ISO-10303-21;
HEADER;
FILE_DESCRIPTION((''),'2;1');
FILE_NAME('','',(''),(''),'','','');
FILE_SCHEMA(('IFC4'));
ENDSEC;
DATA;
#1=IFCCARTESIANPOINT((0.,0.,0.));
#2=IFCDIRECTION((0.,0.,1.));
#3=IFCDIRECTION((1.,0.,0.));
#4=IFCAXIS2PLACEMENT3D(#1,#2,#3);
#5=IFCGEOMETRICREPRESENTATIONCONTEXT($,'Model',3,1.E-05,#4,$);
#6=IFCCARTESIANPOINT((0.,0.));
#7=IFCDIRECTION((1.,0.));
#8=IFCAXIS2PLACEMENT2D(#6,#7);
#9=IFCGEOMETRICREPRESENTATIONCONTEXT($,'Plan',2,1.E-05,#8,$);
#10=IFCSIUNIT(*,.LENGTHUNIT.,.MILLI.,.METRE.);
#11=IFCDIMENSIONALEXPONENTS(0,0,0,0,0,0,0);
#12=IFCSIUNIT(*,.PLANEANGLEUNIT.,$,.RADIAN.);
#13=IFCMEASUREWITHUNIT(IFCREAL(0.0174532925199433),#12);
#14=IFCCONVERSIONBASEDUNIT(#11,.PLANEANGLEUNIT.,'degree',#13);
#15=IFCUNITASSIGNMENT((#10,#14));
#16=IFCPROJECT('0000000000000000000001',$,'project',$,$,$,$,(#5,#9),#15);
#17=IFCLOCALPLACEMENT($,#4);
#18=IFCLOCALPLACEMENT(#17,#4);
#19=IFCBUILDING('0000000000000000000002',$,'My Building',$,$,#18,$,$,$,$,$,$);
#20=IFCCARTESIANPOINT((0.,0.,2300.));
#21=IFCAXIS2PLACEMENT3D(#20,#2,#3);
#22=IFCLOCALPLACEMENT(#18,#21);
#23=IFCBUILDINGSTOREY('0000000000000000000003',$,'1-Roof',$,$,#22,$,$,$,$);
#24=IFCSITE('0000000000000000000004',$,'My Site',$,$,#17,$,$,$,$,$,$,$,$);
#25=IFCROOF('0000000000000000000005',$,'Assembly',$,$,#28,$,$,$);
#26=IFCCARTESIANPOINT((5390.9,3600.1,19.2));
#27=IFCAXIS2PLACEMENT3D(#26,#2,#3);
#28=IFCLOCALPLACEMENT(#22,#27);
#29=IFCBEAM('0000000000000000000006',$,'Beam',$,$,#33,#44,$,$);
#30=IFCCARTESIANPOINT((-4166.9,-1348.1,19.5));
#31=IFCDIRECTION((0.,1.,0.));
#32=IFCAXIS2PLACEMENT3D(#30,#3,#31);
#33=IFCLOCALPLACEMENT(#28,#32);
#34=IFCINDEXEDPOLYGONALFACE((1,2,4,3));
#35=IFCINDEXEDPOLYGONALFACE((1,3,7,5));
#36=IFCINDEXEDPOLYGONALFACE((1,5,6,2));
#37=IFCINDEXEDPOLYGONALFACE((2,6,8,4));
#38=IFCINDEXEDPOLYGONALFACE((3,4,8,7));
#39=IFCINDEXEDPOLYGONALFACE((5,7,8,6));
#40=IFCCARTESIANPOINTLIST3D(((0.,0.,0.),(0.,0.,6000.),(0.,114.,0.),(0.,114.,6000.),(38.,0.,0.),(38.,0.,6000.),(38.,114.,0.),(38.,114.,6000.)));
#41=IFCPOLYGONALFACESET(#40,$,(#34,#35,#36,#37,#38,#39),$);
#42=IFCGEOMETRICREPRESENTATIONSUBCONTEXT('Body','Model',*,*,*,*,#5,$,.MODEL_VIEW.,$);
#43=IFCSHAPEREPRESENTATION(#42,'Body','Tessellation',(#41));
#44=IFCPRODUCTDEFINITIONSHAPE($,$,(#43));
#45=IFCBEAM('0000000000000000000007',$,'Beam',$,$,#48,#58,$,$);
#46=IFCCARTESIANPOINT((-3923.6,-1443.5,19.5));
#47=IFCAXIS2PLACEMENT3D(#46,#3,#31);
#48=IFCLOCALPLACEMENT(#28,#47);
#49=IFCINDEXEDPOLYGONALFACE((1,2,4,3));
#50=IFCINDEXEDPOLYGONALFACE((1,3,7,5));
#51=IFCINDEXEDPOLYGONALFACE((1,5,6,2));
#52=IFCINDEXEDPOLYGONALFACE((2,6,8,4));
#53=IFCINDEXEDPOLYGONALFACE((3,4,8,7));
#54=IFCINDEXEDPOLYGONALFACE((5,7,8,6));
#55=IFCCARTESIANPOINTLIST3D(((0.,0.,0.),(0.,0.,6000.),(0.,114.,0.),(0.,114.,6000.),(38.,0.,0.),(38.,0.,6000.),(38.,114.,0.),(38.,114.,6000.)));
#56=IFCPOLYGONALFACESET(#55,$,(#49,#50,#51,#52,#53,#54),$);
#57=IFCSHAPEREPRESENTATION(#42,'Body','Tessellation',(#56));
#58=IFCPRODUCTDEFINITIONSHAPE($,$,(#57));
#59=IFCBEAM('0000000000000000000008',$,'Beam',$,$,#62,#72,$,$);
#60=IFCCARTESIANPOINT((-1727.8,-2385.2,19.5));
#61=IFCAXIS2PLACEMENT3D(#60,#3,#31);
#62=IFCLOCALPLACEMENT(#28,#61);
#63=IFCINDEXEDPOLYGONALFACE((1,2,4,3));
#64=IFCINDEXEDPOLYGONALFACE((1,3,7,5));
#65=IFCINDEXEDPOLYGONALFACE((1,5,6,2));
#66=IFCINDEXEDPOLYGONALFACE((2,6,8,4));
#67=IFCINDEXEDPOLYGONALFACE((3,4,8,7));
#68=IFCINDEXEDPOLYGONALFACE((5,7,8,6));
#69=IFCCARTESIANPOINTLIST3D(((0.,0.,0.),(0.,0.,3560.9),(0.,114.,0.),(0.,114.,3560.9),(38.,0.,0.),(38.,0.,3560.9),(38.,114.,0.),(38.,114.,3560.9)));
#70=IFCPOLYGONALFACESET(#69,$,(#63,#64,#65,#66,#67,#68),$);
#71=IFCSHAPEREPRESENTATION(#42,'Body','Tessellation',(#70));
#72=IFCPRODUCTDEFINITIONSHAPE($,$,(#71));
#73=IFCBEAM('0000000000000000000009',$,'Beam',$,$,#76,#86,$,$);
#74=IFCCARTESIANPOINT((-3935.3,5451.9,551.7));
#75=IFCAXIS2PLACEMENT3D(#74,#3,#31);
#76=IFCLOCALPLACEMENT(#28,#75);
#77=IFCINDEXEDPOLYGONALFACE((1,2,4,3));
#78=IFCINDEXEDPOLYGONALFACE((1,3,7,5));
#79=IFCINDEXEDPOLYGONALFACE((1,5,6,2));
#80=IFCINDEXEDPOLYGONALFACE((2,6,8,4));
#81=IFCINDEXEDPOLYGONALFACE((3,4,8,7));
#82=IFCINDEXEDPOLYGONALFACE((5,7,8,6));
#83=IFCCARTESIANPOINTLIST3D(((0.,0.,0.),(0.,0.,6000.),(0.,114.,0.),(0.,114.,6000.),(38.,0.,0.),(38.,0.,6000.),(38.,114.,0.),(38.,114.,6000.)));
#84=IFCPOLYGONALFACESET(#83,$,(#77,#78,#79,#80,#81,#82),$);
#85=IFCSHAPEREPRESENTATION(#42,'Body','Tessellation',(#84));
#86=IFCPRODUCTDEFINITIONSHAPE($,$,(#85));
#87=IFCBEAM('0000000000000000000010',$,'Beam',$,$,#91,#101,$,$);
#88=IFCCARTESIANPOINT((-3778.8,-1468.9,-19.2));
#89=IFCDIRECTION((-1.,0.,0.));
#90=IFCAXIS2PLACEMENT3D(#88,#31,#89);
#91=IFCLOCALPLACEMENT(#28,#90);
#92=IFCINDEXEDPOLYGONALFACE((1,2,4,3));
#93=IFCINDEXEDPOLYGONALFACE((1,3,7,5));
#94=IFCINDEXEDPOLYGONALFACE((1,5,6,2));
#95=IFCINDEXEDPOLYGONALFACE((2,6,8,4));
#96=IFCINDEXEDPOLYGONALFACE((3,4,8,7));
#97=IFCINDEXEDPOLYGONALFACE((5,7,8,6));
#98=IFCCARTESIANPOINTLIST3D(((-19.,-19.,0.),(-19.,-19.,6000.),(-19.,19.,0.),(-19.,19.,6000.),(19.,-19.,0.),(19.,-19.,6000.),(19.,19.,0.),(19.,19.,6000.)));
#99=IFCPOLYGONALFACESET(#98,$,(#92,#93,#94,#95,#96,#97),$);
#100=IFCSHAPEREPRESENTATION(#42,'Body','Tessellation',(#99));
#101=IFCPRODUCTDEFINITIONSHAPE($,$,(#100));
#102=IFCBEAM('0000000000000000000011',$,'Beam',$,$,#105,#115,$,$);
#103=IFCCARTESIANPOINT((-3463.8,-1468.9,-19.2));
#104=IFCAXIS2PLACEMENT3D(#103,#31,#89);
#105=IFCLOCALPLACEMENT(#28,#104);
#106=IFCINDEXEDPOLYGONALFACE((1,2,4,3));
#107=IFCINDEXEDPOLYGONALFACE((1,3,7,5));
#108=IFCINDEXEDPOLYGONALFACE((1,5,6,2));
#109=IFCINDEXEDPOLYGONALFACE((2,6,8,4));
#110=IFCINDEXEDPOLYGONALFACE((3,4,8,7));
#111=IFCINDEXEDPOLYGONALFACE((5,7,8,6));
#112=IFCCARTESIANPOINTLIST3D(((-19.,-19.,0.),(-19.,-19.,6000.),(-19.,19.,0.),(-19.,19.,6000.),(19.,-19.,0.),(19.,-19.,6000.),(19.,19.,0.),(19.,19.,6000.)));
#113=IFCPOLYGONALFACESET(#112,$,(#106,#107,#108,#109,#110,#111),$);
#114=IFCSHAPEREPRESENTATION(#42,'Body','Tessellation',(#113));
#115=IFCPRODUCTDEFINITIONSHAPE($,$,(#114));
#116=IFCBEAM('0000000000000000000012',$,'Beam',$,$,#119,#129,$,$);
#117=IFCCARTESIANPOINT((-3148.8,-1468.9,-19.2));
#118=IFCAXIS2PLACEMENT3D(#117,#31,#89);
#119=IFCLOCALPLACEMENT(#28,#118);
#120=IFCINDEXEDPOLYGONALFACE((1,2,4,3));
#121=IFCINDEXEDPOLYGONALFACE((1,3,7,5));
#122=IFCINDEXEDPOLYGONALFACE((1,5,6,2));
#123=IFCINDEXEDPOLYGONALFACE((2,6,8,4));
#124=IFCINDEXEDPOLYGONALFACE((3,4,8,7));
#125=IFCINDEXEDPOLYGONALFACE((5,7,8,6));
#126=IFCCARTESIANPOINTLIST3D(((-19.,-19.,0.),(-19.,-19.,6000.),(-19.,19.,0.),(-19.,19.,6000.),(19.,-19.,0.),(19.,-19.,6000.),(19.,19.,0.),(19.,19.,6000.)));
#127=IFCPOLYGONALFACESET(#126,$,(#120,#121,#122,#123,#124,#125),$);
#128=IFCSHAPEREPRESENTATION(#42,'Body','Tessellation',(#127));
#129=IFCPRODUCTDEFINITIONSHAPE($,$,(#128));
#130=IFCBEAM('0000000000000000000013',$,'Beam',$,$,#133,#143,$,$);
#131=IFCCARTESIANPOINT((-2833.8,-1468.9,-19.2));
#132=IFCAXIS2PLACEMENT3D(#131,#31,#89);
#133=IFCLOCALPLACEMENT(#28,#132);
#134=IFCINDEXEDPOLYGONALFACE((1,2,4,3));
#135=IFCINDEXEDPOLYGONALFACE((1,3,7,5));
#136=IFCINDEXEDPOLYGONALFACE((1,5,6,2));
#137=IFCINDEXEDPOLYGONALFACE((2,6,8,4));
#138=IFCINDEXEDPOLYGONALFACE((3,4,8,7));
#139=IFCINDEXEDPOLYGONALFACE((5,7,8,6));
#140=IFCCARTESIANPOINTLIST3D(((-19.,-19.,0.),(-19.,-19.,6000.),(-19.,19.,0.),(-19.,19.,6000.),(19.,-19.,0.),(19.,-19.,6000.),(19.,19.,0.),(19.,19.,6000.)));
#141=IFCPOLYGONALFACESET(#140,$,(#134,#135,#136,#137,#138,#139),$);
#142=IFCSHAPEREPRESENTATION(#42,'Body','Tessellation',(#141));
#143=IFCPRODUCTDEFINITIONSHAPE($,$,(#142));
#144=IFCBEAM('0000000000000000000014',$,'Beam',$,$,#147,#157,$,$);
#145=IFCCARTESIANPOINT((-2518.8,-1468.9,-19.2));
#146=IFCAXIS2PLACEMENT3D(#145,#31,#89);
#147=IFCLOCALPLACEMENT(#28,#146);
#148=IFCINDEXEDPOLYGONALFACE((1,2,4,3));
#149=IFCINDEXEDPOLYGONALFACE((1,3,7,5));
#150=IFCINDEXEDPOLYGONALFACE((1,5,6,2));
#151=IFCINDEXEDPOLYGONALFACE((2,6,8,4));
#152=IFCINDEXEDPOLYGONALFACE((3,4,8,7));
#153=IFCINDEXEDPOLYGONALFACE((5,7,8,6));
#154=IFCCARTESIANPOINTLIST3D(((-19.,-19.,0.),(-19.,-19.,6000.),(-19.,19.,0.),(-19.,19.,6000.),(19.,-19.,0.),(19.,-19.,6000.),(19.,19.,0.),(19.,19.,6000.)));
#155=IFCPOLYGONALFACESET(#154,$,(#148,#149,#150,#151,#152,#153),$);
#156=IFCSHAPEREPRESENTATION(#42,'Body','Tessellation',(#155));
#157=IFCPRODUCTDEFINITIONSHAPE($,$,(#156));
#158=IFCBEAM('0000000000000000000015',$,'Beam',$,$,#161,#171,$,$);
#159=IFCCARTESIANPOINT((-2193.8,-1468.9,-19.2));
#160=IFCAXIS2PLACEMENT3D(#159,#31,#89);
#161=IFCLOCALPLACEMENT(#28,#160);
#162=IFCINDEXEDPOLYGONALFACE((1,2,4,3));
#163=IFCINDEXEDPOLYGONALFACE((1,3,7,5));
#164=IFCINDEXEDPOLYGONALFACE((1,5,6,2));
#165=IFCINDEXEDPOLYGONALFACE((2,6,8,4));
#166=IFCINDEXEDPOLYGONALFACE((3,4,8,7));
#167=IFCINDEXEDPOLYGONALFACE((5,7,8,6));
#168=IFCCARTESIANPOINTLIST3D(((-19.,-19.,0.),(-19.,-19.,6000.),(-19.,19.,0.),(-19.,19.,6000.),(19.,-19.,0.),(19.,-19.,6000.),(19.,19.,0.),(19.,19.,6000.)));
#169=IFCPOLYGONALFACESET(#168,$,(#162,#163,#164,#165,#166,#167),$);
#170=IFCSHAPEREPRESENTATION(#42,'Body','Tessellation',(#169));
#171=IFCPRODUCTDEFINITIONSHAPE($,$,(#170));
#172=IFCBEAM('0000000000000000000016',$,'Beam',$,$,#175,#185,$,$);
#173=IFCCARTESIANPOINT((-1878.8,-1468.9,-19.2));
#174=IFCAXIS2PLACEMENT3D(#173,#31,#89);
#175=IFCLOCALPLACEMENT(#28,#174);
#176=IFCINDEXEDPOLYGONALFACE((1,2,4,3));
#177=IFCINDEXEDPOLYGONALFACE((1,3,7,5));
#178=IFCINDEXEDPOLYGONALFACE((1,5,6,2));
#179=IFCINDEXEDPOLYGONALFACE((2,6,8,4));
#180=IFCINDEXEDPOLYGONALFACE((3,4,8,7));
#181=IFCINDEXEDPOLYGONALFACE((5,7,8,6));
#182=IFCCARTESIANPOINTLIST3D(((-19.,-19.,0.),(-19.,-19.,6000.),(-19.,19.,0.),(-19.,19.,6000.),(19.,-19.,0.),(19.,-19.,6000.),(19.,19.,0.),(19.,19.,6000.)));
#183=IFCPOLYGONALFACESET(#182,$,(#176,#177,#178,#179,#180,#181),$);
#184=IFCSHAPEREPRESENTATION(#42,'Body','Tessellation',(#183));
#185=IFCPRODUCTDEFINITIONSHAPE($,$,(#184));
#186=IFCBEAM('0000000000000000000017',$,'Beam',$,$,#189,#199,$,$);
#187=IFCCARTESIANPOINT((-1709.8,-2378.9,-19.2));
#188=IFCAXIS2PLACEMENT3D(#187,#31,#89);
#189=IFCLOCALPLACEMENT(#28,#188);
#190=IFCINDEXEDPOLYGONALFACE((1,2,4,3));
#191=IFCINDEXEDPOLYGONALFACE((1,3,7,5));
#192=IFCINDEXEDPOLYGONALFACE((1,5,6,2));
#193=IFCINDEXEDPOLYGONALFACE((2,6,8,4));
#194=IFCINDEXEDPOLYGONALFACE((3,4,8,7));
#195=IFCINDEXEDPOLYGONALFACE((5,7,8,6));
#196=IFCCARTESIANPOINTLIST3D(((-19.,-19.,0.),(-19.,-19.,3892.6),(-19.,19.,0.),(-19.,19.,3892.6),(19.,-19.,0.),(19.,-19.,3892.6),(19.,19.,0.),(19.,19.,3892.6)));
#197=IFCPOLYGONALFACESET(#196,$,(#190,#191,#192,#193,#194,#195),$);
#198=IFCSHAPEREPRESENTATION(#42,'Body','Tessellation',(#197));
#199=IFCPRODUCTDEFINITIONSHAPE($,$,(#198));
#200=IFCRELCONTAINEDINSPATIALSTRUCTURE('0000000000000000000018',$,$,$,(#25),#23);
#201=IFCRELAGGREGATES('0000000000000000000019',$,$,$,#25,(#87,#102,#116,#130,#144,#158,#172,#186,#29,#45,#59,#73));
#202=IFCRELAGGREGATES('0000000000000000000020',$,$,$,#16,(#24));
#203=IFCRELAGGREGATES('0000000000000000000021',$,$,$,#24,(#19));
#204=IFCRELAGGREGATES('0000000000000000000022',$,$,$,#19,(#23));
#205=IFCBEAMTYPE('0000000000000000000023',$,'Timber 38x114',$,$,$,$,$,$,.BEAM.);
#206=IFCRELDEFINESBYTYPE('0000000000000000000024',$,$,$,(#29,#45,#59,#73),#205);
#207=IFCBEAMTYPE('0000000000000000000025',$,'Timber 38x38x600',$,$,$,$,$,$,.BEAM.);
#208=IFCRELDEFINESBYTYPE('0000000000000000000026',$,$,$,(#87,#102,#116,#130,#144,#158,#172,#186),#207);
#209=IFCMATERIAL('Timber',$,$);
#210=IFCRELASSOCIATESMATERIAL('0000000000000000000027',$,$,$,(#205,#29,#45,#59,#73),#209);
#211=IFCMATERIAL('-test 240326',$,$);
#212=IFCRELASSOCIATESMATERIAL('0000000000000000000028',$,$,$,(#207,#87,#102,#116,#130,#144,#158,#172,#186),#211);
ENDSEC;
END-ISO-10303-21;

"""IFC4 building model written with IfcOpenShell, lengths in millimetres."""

from ifc_helpers import new_model, entity, si_unit, converted_unit, frame, origin_with_axes, origin_2d_with_axis, place, context, subcontext, project, spatial, line, indexed_curve, rectangle, outline, extrude, material, material_profile, profile_set, profile_usage, type_object, element, aggregate, save


model = new_model("IFC4")

# Units and contexts
model_context = context("Model", 3, precision=1e-05, world=origin_with_axes())
plan_context = context("Plan", 2, precision=1e-05, world=origin_2d_with_axis())
body_context = subcontext(model_context, "Body", "Model", "MODEL_VIEW")
ifc_project = project(units=[si_unit("LENGTHUNIT", "METRE", prefix="MILLI"), converted_unit("PLANEANGLEUNIT", "degree", entity("IfcReal", 0.0174532925199433), si_unit("PLANEANGLEUNIT", "RADIAN"), dimensions=[0, 0, 0, 0, 0, 0, 0])], contexts=[model_context, plan_context])

# Site, building, storey
site_placement = place(None, origin_with_axes())
site = spatial("IfcSite", under=ifc_project, at=site_placement, Name="My Site")
building_placement = place(site_placement, origin_with_axes())
building = spatial("IfcBuilding", under=site, at=building_placement, Name="My Building")
storey_placement = place(building_placement, frame((0.0, 0.0, 2300.0), z_axis=(0.0, 0.0, 1.0), x_axis=(1.0, 0.0, 0.0)))
storey = spatial("IfcBuildingStorey", under=building, at=storey_placement, Name="1-Roof")

# Roof, beams
roof_placement = place(storey_placement, frame((5390.9, 3600.1, 19.2), z_axis=(0.0, 0.0, 1.0), x_axis=(1.0, 0.0, 0.0)))
roof = element("IfcRoof", 1, at=roof_placement, inside=storey, Name="Assembly")
ifc_material_1 = material(Name="Timber")
ifc_material_profile_1 = material_profile(ifc_material_1, outline(indexed_curve([(0.0, 0.0), (38.0, 0.0), (38.0, 114.0), (0.0, 114.0)], segments=[line(3, 2), line(2, 1), line(1, 4), line(4, 3)], self_intersect=False)))
ifc_profile_set_1 = profile_set([ifc_material_profile_1])
beam_type_1 = type_object("IfcBeamType", Name="Timber 38x114", PredefinedType="BEAM", material=ifc_profile_set_1)
ifc_profile_usage_1 = profile_usage(ifc_profile_set_1, cardinal=5)
beam_1_placement = place(roof_placement, frame((-4166.9, -1348.1, 19.5), z_axis=(1.0, 0.0, 0.0), x_axis=(0.0, 1.0, 0.0)))
beam_1 = element("IfcBeam", 2, at=beam_1_placement, type_object=beam_type_1, material=ifc_profile_usage_1, Name="Beam", context=body_context, shape_type="SweptSolid", body=[
    extrude(outline(indexed_curve([(0.0, 0.0), (38.0, 0.0), (38.0, 114.0), (0.0, 114.0)], segments=[line(3, 2), line(2, 1), line(1, 4), line(4, 3)], self_intersect=False)), origin_with_axes(), (0.0, 0.0, 1.0), 6000.0),
])
ifc_profile_usage_2 = profile_usage(ifc_profile_set_1, cardinal=5)
beam_2_placement = place(roof_placement, frame((-3923.6, -1443.5, 19.5), z_axis=(1.0, 0.0, 0.0), x_axis=(0.0, 1.0, 0.0)))
beam_2 = element("IfcBeam", 3, at=beam_2_placement, type_object=beam_type_1, material=ifc_profile_usage_2, Name="Beam", context=body_context, shape_type="SweptSolid", body=[
    extrude(outline(indexed_curve([(0.0, 0.0), (38.0, 0.0), (38.0, 114.0), (0.0, 114.0)], segments=[line(3, 2), line(2, 1), line(1, 4), line(4, 3)], self_intersect=False)), origin_with_axes(), (0.0, 0.0, 1.0), 6000.0),
])
ifc_profile_usage_3 = profile_usage(ifc_profile_set_1, cardinal=5)
beam_3_placement = place(roof_placement, frame((-1727.8, -2385.2, 19.5), z_axis=(1.0, 0.0, 0.0), x_axis=(0.0, 1.0, 0.0)))
beam_3 = element("IfcBeam", 4, at=beam_3_placement, type_object=beam_type_1, material=ifc_profile_usage_3, Name="Beam", context=body_context, shape_type="SweptSolid", body=[
    extrude(outline(indexed_curve([(0.0, 0.0), (38.0, 0.0), (38.0, 114.0), (0.0, 114.0)], segments=[line(3, 2), line(2, 1), line(1, 4), line(4, 3)], self_intersect=False)), origin_with_axes(), (0.0, 0.0, 1.0), 3560.9),
])
ifc_profile_usage_4 = profile_usage(ifc_profile_set_1, cardinal=5)
beam_4_placement = place(roof_placement, frame((-3935.3, 5451.9, 551.7), z_axis=(1.0, 0.0, 0.0), x_axis=(0.0, 1.0, 0.0)))
beam_4 = element("IfcBeam", 5, at=beam_4_placement, type_object=beam_type_1, material=ifc_profile_usage_4, Name="Beam", context=body_context, shape_type="SweptSolid", body=[
    extrude(outline(indexed_curve([(0.0, 0.0), (38.0, 0.0), (38.0, 114.0), (0.0, 114.0)], segments=[line(3, 2), line(2, 1), line(1, 4), line(4, 3)], self_intersect=False)), origin_with_axes(), (0.0, 0.0, 1.0), 6000.0),
])
ifc_material_2 = material(Name="-test 240326")
ifc_material_profile_2 = material_profile(ifc_material_2, rectangle(XDim=38.0, YDim=38.0))
ifc_profile_set_2 = profile_set([ifc_material_profile_2])
ifc_profile_usage_5 = profile_usage(ifc_profile_set_2, cardinal=5)
beam_type_2 = type_object("IfcBeamType", Name="Timber 38x38x600", PredefinedType="BEAM", material=ifc_profile_set_2)
beam_5_placement = place(roof_placement, frame((-3778.8, -1468.9, -19.2), z_axis=(0.0, 1.0, 0.0), x_axis=(-1.0, 0.0, 0.0)))
beam_5 = element("IfcBeam", 6, at=beam_5_placement, type_object=beam_type_2, material=ifc_profile_usage_5, Name="Beam", context=body_context, shape_type="SweptSolid", body=[
    extrude(rectangle(XDim=38.0, YDim=38.0), origin_with_axes(), (0.0, 0.0, 1.0), 6000.0),
])
ifc_profile_usage_6 = profile_usage(ifc_profile_set_2, cardinal=5)
beam_6_placement = place(roof_placement, frame((-3463.8, -1468.9, -19.2), z_axis=(0.0, 1.0, 0.0), x_axis=(-1.0, 0.0, 0.0)))
beam_6 = element("IfcBeam", 7, at=beam_6_placement, type_object=beam_type_2, material=ifc_profile_usage_6, Name="Beam", context=body_context, shape_type="SweptSolid", body=[
    extrude(rectangle(XDim=38.0, YDim=38.0), origin_with_axes(), (0.0, 0.0, 1.0), 6000.0),
])
ifc_profile_usage_7 = profile_usage(ifc_profile_set_2, cardinal=5)
beam_7_placement = place(roof_placement, frame((-3148.8, -1468.9, -19.2), z_axis=(0.0, 1.0, 0.0), x_axis=(-1.0, 0.0, 0.0)))
beam_7 = element("IfcBeam", 8, at=beam_7_placement, type_object=beam_type_2, material=ifc_profile_usage_7, Name="Beam", context=body_context, shape_type="SweptSolid", body=[
    extrude(rectangle(XDim=38.0, YDim=38.0), origin_with_axes(), (0.0, 0.0, 1.0), 6000.0),
])
ifc_profile_usage_8 = profile_usage(ifc_profile_set_2, cardinal=5)
beam_8_placement = place(roof_placement, frame((-2833.8, -1468.9, -19.2), z_axis=(0.0, 1.0, 0.0), x_axis=(-1.0, 0.0, 0.0)))
beam_8 = element("IfcBeam", 9, at=beam_8_placement, type_object=beam_type_2, material=ifc_profile_usage_8, Name="Beam", context=body_context, shape_type="SweptSolid", body=[
    extrude(rectangle(XDim=38.0, YDim=38.0), origin_with_axes(), (0.0, 0.0, 1.0), 6000.0),
])
ifc_profile_usage_9 = profile_usage(ifc_profile_set_2, cardinal=5)
beam_9_placement = place(roof_placement, frame((-2518.8, -1468.9, -19.2), z_axis=(0.0, 1.0, 0.0), x_axis=(-1.0, 0.0, 0.0)))
beam_9 = element("IfcBeam", 10, at=beam_9_placement, type_object=beam_type_2, material=ifc_profile_usage_9, Name="Beam", context=body_context, shape_type="SweptSolid", body=[
    extrude(rectangle(XDim=38.0, YDim=38.0), origin_with_axes(), (0.0, 0.0, 1.0), 6000.0),
])
ifc_profile_usage_10 = profile_usage(ifc_profile_set_2, cardinal=5)
beam_10_placement = place(roof_placement, frame((-2193.8, -1468.9, -19.2), z_axis=(0.0, 1.0, 0.0), x_axis=(-1.0, 0.0, 0.0)))
beam_10 = element("IfcBeam", 11, at=beam_10_placement, type_object=beam_type_2, material=ifc_profile_usage_10, Name="Beam", context=body_context, shape_type="SweptSolid", body=[
    extrude(rectangle(XDim=38.0, YDim=38.0), origin_with_axes(), (0.0, 0.0, 1.0), 6000.0),
])
ifc_profile_usage_11 = profile_usage(ifc_profile_set_2, cardinal=5)
beam_11_placement = place(roof_placement, frame((-1878.8, -1468.9, -19.2), z_axis=(0.0, 1.0, 0.0), x_axis=(-1.0, 0.0, 0.0)))
beam_11 = element("IfcBeam", 12, at=beam_11_placement, type_object=beam_type_2, material=ifc_profile_usage_11, Name="Beam", context=body_context, shape_type="SweptSolid", body=[
    extrude(rectangle(XDim=38.0, YDim=38.0), origin_with_axes(), (0.0, 0.0, 1.0), 6000.0),
])
ifc_profile_usage_12 = profile_usage(ifc_profile_set_2, cardinal=5)
beam_12_placement = place(roof_placement, frame((-1709.8, -2378.9, -19.2), z_axis=(0.0, 1.0, 0.0), x_axis=(-1.0, 0.0, 0.0)))
beam_12 = element("IfcBeam", 13, at=beam_12_placement, type_object=beam_type_2, material=ifc_profile_usage_12, Name="Beam", context=body_context, shape_type="SweptSolid", body=[
    extrude(rectangle(XDim=38.0, YDim=38.0), origin_with_axes(), (0.0, 0.0, 1.0), 3892.6),
])
aggregate(roof, [beam_5, beam_6, beam_7, beam_8, beam_9, beam_10, beam_11, beam_12, beam_1, beam_2, beam_3, beam_4])

save(model, "model.ifc")
